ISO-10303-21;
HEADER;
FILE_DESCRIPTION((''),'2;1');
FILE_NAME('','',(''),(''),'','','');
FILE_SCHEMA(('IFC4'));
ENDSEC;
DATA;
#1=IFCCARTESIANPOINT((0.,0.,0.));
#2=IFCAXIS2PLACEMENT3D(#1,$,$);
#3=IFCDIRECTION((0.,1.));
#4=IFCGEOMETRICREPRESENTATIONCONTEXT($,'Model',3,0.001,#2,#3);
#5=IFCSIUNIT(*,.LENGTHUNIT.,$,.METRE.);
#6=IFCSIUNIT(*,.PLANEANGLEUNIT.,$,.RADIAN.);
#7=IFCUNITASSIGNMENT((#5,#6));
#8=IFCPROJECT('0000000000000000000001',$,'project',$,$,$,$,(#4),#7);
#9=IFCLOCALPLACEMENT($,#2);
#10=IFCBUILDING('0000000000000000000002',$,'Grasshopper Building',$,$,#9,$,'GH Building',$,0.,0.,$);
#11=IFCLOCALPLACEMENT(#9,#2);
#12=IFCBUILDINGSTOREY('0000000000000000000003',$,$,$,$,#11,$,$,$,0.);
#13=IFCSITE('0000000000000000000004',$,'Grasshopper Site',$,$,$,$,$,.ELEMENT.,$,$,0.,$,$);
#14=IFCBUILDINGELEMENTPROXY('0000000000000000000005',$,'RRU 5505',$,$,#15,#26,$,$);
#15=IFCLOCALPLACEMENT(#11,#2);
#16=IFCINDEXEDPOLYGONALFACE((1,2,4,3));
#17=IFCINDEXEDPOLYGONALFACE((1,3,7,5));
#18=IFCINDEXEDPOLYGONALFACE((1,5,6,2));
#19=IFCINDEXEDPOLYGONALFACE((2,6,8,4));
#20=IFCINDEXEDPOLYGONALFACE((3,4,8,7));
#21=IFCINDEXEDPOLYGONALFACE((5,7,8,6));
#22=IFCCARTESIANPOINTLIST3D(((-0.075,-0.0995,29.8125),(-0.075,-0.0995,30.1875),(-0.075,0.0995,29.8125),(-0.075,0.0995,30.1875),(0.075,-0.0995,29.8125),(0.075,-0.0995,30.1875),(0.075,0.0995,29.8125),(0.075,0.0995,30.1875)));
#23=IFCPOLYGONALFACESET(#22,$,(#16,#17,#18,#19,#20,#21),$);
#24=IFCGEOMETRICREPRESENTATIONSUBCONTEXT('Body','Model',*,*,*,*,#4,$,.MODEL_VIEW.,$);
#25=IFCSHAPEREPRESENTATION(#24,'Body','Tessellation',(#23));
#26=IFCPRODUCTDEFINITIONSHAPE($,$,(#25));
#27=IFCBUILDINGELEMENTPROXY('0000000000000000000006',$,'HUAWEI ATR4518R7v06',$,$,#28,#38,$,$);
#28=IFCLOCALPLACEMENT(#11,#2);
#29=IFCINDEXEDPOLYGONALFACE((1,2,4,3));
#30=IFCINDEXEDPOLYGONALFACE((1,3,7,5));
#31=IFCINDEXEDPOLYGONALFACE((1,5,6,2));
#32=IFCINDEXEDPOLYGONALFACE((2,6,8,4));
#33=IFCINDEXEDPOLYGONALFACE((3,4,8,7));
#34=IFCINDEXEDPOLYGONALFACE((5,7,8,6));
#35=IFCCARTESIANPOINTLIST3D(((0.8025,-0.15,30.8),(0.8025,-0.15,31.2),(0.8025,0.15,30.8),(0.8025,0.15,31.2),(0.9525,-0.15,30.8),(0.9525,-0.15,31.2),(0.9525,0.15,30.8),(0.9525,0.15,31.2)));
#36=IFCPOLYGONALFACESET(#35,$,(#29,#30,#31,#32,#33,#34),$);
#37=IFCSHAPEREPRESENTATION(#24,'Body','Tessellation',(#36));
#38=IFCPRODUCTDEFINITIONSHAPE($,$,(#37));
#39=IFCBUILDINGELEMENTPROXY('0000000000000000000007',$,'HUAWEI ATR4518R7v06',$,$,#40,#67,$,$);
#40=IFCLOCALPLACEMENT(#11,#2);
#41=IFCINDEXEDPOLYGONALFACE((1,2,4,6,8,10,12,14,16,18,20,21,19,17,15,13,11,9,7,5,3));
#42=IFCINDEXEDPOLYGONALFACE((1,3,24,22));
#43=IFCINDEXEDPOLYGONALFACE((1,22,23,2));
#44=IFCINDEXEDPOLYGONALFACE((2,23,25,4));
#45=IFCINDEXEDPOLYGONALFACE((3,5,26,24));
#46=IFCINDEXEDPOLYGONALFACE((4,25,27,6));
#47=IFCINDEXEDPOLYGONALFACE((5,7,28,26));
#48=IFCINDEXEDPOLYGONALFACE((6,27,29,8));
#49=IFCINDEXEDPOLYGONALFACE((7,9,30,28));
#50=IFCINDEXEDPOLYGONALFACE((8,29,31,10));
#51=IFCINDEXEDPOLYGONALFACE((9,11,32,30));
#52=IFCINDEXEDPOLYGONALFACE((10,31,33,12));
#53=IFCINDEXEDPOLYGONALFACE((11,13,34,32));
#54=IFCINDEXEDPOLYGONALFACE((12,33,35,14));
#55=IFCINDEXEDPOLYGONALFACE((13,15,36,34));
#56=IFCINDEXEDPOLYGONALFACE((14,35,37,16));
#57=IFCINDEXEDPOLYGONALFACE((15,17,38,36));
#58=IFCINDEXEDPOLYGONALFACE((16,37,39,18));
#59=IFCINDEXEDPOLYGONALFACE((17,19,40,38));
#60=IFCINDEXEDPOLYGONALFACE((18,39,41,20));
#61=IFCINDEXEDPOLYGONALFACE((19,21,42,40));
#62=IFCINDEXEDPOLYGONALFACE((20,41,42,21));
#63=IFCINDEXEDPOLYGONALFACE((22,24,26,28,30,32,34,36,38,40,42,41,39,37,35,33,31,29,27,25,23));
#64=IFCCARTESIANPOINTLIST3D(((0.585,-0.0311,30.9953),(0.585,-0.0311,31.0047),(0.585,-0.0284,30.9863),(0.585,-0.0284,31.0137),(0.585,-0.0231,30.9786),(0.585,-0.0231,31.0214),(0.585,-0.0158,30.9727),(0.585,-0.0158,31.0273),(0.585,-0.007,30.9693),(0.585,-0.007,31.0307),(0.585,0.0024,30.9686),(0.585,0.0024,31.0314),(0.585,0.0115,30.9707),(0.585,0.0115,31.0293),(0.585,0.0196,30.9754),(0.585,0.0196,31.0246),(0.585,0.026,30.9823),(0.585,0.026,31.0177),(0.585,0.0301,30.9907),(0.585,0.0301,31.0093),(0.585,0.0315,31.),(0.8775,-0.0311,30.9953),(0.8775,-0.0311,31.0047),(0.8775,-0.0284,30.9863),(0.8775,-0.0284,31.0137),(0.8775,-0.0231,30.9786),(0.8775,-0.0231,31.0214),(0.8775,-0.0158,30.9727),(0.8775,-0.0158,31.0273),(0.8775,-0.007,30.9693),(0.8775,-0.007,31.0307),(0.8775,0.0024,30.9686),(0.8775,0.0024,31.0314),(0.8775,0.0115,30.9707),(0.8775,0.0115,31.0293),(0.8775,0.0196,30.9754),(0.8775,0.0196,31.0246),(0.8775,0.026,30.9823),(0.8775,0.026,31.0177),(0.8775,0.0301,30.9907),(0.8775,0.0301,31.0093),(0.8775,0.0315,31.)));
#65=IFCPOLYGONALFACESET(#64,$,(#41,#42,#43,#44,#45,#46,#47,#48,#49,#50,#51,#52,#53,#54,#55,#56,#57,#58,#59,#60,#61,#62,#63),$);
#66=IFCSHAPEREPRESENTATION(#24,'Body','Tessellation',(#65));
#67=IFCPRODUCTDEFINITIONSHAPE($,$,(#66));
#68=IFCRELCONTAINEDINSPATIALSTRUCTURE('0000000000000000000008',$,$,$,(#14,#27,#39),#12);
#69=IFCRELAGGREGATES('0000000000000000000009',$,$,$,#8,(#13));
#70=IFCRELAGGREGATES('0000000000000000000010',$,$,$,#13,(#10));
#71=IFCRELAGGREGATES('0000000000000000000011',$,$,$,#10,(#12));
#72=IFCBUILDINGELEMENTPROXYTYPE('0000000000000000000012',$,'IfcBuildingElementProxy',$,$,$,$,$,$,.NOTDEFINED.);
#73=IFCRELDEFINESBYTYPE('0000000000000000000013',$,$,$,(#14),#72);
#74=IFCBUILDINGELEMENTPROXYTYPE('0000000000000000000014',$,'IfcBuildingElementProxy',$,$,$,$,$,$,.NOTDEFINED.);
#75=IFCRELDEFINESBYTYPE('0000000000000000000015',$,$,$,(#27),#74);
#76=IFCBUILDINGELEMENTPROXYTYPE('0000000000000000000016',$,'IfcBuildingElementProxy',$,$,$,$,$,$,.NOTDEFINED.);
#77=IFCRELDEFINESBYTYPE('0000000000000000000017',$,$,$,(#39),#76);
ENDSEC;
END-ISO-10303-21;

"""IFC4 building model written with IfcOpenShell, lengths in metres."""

from ifc_helpers import new_model, si_unit, direction, frame, frame_2d, origin, place, context, subcontext, project, spatial, rectangle, circle, extrude, source, transform, mapped, type_object, type_shapes, element, save


model = new_model("IFC4")

# Units and contexts
model_context = context("Model", 3, precision=0.001, world=origin(), true_north=direction((0.0, 1.0)))
body_context = subcontext(model_context, "Body", "Model", "MODEL_VIEW")
ifc_project = project(units=[si_unit("LENGTHUNIT", "METRE"), si_unit("PLANEANGLEUNIT", "RADIAN")], contexts=[model_context])

# Site, building, storey
site = spatial("IfcSite", under=ifc_project, Name="Grasshopper Site", CompositionType="ELEMENT", RefElevation=0.0)
building_placement = place(None, origin())
building = spatial("IfcBuilding", under=site, at=building_placement, Name="Grasshopper Building", LongName="GH Building", ElevationOfRefHeight=0.0, ElevationOfTerrain=0.0)
storey_placement = place(building_placement, origin())
storey = spatial("IfcBuildingStorey", under=building, at=storey_placement, Elevation=0.0)

# Building element proxies
building_element_proxy_type_1 = type_object("IfcBuildingElementProxyType", Name="IfcBuildingElementProxy", PredefinedType="NOTDEFINED")
shared_shape_1 = source(origin(), body_context, "Body", "SweptSolid", [
    extrude(rectangle(XDim=0.375, YDim=0.199, at=frame_2d((0.0, 0.0), x_axis=(0.0, 1.0))), frame((0.075, 0.0, 30.0), z_axis=(-1.0, 0.0, 0.0), x_axis=(0.0, 1.0, 0.0)), (0.0, 0.0, 1.0), 0.15),
])
type_shapes(building_element_proxy_type_1, [shared_shape_1])
for number, where, name in (
    (1, (0.0, 0.0, 0.0), "RRU 5505"),
):
    element("IfcBuildingElementProxy", number, at=place(storey_placement, frame(where)), inside=storey, type_object=building_element_proxy_type_1, Name=name, context=body_context, shape_type="MappedRepresentation", body=[
        mapped(shared_shape_1, transform((0.0, 0.0, 0.0), scale=1.0)),
    ])
building_element_proxy_type_2 = type_object("IfcBuildingElementProxyType", Name="IfcBuildingElementProxy", PredefinedType="NOTDEFINED")
shared_shape_2 = source(origin(), body_context, "Body", "SweptSolid", [
    extrude(rectangle(XDim=0.4, YDim=0.3, at=frame_2d((0.0, 0.0), x_axis=(0.0, 1.0))), frame((0.9525, 0.0, 31.0), z_axis=(-1.0, 0.0, 0.0), x_axis=(0.0, 1.0, 0.0)), (0.0, 0.0, 1.0), 0.15),
])
type_shapes(building_element_proxy_type_2, [shared_shape_2])
for number, where, name in (
    (2, (0.0, 0.0, 0.0), "HUAWEI ATR4518R7v06"),
):
    element("IfcBuildingElementProxy", number, at=place(storey_placement, frame(where)), inside=storey, type_object=building_element_proxy_type_2, Name=name, context=body_context, shape_type="MappedRepresentation", body=[
        mapped(shared_shape_2, transform((0.0, 0.0, 0.0), scale=1.0)),
    ])
building_element_proxy_type_3 = type_object("IfcBuildingElementProxyType", Name="IfcBuildingElementProxy", PredefinedType="NOTDEFINED")
shared_shape_3 = source(origin(), body_context, "Body", "SweptSolid", [
    extrude(circle(Radius=0.0315), frame((0.585, 0.0, 31.0), z_axis=(1.0, 0.0, 0.0), x_axis=(0.0, 1.0, 0.0)), (0.0, 0.0, 1.0), 0.2925),
])
type_shapes(building_element_proxy_type_3, [shared_shape_3])
for number, where, name in (
    (3, (0.0, 0.0, 0.0), "HUAWEI ATR4518R7v06"),
):
    element("IfcBuildingElementProxy", number, at=place(storey_placement, frame(where)), inside=storey, type_object=building_element_proxy_type_3, Name=name, context=body_context, shape_type="MappedRepresentation", body=[
        mapped(shared_shape_3, transform((0.0, 0.0, 0.0), scale=1.0)),
    ])

save(model, "model.ifc")
